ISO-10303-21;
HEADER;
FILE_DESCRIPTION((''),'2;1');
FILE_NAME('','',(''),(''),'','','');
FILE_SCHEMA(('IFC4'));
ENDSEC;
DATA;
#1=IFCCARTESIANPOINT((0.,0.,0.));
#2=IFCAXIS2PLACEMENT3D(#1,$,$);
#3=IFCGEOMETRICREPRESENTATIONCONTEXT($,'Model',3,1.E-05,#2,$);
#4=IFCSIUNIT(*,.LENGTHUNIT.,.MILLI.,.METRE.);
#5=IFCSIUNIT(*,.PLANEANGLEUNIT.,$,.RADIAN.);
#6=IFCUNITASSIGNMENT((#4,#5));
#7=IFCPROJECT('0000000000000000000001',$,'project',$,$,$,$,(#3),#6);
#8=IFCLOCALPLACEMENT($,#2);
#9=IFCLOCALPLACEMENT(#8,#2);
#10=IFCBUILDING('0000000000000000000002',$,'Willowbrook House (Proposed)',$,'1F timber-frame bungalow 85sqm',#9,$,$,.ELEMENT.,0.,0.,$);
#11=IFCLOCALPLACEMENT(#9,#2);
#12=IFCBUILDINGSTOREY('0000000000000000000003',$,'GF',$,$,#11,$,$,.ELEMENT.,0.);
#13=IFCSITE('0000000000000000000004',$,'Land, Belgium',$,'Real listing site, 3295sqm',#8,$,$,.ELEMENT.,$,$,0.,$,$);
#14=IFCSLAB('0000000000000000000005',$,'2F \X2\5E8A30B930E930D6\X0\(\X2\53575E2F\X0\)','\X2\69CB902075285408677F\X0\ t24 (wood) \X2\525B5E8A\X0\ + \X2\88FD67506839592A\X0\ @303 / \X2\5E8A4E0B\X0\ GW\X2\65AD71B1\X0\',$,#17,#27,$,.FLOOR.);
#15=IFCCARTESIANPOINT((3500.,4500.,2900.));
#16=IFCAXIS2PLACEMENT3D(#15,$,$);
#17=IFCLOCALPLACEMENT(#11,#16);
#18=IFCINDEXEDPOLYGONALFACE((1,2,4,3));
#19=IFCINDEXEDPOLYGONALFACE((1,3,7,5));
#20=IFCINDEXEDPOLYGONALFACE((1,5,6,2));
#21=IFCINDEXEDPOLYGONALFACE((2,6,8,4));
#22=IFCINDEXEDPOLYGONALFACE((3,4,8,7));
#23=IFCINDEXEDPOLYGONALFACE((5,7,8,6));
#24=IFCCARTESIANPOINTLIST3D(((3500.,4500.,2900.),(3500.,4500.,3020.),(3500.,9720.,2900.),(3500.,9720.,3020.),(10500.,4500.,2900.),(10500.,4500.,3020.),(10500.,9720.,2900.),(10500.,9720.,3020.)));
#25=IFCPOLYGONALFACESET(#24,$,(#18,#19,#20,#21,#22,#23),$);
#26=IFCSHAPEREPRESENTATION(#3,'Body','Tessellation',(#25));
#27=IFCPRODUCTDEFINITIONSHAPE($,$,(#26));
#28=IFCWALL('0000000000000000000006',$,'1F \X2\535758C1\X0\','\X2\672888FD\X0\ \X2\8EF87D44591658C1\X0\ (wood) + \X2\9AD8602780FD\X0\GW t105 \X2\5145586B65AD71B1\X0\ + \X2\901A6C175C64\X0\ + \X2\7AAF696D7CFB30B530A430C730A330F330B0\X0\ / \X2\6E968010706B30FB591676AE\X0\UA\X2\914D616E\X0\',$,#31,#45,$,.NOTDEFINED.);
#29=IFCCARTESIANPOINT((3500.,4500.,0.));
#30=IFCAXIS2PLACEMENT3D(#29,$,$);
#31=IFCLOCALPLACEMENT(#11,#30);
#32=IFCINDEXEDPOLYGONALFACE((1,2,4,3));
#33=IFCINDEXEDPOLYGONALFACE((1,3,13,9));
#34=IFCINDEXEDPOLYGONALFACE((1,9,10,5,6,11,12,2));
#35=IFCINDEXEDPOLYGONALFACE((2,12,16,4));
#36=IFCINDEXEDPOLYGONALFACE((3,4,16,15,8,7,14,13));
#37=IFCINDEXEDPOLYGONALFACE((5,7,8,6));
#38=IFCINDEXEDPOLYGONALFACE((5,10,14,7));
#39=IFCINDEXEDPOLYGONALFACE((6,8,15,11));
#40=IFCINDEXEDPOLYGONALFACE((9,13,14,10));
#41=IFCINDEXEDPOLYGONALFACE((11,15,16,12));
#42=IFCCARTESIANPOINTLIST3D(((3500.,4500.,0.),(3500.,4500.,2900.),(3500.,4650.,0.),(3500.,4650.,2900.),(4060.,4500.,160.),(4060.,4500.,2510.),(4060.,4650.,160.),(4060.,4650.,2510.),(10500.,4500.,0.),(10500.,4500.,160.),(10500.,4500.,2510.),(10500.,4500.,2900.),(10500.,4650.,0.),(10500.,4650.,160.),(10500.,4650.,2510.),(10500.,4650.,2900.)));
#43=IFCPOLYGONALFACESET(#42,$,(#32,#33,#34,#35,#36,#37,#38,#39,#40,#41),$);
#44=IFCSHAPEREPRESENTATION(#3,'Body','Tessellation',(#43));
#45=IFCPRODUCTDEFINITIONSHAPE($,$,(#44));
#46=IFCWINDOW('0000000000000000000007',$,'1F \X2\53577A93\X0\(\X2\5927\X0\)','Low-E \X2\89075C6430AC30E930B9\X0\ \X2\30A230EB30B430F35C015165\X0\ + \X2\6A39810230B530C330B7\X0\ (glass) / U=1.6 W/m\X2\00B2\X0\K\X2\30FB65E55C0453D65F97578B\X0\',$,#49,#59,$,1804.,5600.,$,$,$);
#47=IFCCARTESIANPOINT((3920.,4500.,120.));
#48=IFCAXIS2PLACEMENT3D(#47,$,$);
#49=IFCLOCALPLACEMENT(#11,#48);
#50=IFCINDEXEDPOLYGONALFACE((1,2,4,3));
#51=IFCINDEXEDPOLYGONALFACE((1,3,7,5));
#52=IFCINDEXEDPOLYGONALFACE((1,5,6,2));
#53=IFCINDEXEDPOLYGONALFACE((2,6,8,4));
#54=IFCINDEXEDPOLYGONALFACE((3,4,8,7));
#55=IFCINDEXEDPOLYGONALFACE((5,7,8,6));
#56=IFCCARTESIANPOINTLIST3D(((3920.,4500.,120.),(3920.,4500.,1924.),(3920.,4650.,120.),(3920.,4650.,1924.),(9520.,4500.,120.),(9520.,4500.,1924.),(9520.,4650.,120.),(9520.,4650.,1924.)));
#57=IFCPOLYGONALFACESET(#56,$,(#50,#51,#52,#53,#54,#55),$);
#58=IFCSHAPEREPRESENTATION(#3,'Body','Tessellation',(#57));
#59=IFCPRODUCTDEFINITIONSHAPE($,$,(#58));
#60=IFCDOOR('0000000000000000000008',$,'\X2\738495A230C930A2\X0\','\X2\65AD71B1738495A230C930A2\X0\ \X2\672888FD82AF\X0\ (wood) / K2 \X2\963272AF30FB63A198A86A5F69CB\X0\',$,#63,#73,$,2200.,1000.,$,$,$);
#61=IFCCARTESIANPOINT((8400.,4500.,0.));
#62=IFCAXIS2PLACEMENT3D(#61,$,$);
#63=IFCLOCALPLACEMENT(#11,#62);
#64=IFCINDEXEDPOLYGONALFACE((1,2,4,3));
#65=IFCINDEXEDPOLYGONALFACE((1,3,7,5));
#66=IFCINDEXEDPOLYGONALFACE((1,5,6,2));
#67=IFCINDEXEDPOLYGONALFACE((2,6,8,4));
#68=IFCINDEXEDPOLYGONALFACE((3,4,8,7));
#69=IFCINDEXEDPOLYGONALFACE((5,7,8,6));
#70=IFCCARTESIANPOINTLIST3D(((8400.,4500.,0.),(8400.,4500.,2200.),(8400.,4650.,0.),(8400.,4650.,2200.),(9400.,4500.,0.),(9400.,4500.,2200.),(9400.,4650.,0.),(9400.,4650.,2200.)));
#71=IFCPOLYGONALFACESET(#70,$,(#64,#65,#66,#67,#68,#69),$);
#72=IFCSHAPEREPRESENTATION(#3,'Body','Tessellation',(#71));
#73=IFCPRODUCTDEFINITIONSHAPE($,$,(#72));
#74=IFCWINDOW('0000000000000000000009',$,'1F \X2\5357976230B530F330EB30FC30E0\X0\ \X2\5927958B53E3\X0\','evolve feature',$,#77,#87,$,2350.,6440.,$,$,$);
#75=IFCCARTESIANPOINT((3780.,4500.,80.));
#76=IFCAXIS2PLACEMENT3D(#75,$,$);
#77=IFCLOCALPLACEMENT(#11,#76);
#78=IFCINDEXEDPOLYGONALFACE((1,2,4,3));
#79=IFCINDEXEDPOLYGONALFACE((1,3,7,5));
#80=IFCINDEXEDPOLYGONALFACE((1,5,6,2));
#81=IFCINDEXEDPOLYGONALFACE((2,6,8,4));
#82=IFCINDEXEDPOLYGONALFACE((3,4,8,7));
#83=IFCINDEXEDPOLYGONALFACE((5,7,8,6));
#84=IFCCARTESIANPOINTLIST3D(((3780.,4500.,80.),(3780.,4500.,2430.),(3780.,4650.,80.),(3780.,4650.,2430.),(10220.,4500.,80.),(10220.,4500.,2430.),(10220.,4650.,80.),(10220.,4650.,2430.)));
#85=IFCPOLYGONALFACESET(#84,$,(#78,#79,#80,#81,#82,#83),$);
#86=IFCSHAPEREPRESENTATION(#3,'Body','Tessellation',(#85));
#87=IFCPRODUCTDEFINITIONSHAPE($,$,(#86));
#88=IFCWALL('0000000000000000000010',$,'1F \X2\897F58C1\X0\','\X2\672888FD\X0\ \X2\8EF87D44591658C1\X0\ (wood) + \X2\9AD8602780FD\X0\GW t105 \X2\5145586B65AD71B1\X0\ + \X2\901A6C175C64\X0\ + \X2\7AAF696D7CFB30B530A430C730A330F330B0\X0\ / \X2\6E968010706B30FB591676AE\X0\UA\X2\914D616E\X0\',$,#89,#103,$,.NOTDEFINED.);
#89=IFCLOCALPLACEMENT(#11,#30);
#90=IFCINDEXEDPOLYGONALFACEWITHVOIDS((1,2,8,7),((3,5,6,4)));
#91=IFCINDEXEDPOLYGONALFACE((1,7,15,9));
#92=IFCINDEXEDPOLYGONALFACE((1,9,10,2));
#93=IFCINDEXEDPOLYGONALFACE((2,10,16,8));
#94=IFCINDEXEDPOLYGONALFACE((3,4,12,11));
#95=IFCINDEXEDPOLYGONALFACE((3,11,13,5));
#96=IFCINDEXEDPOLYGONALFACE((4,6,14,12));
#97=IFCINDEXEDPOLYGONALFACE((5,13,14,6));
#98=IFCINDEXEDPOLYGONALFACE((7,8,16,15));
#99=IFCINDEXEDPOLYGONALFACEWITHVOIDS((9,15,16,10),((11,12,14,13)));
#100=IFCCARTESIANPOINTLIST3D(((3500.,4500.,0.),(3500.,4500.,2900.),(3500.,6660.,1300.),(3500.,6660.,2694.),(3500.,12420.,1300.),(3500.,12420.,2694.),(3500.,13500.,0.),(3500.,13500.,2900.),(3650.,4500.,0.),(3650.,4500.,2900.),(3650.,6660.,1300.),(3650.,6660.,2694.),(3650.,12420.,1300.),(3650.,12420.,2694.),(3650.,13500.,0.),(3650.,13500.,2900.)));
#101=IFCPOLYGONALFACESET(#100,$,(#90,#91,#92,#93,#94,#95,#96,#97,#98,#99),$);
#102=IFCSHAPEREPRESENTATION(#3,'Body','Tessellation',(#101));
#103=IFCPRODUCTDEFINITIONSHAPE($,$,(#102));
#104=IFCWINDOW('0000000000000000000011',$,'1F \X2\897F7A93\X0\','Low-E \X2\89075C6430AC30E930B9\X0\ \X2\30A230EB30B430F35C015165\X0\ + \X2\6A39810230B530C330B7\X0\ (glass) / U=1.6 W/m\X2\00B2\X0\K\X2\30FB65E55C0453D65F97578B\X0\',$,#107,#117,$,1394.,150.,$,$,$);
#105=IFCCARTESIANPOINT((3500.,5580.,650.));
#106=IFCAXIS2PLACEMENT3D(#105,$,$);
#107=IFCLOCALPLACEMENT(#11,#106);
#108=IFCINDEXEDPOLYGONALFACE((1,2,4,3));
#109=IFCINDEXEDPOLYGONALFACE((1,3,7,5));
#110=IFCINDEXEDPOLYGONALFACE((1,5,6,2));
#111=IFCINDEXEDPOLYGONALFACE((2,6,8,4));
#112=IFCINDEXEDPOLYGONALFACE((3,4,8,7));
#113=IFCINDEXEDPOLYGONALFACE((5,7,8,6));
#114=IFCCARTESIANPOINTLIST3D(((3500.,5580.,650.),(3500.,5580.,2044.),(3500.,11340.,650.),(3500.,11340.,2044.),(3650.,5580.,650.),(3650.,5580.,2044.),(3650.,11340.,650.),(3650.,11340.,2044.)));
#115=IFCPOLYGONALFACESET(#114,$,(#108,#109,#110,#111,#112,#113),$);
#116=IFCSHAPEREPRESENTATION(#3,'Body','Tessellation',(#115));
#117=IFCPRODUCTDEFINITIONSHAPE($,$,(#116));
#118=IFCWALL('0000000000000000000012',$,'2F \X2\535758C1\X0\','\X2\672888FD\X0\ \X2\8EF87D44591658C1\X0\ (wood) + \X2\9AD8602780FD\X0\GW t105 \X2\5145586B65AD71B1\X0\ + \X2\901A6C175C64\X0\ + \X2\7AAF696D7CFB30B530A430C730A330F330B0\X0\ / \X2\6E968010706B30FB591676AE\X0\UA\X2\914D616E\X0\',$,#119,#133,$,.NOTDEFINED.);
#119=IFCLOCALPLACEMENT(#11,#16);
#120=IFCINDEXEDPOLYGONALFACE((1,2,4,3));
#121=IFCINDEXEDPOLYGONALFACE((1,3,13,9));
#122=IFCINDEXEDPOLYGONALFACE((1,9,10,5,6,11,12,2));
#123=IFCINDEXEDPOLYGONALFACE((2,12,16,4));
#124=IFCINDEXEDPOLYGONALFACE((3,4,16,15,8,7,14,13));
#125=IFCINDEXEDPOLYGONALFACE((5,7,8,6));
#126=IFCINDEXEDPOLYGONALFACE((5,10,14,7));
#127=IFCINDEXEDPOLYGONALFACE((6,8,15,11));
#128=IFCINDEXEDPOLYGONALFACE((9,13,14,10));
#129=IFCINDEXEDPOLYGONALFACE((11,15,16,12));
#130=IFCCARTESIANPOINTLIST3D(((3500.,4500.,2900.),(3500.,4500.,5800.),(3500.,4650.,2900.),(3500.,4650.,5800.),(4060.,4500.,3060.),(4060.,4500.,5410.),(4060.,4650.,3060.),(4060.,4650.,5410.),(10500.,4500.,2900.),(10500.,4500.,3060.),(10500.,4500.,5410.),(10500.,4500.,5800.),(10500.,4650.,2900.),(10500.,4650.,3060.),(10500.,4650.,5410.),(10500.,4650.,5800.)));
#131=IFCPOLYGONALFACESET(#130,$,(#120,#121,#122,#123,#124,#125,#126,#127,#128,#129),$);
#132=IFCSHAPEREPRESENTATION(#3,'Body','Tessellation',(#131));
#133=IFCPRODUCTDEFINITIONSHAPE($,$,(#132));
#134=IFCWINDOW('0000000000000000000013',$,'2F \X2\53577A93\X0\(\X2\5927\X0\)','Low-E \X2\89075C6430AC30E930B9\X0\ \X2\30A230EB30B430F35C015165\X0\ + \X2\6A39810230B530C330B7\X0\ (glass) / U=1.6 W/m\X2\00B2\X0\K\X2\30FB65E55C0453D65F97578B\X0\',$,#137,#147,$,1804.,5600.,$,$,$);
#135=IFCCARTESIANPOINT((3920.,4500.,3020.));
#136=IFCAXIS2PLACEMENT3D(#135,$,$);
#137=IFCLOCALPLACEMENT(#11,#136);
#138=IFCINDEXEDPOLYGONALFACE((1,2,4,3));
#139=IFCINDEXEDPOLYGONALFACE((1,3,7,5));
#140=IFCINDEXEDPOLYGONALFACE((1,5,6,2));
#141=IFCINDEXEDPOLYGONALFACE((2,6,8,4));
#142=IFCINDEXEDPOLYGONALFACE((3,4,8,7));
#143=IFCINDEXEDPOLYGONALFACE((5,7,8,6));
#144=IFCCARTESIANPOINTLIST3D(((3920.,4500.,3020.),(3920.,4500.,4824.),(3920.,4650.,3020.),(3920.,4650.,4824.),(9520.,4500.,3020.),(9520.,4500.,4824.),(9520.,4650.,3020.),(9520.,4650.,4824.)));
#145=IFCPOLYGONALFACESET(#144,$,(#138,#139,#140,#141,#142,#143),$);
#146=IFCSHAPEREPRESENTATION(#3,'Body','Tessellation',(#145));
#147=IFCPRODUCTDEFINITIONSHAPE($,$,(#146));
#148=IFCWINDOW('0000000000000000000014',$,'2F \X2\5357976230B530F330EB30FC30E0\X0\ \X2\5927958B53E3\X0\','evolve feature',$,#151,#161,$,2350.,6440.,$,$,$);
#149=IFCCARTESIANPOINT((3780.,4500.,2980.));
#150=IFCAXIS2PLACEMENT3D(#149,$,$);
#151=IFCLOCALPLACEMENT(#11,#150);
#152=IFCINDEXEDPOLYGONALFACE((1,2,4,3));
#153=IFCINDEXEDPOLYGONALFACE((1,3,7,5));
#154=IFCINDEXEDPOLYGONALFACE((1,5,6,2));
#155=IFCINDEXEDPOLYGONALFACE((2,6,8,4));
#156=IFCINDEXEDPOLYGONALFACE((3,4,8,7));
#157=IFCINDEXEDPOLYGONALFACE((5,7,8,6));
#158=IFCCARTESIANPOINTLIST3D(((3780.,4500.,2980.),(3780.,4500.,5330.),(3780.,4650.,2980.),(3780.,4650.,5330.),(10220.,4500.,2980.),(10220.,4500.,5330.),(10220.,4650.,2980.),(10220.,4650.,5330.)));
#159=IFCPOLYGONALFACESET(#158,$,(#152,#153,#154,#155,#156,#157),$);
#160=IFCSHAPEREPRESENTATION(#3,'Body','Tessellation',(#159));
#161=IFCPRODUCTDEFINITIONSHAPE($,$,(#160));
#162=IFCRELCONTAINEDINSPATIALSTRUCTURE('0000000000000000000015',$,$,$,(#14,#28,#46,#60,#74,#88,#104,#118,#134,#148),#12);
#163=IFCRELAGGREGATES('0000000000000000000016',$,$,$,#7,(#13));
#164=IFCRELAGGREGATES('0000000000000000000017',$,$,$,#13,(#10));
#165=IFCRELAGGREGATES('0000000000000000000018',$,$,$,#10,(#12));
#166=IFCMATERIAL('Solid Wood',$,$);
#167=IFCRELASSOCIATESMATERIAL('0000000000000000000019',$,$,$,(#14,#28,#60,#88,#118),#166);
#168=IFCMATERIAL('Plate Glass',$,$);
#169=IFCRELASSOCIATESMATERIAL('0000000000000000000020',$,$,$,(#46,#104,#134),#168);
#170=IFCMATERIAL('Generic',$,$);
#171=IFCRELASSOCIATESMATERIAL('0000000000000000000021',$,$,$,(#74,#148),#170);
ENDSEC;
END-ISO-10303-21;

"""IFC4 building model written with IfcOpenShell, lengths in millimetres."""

from ifc_helpers import new_model, si_unit, frame, frame_2d, origin, place, context, project, spatial, rectangle, extrude, material, element, fill, save


model = new_model("IFC4")

# Units and contexts
model_context = context("Model", 3, precision=1e-05, world=origin())
ifc_project = project(units=[si_unit("LENGTHUNIT", "METRE", prefix="MILLI"), si_unit("PLANEANGLEUNIT", "RADIAN")], contexts=[model_context])

# Site, building, storey
site_placement = place(None, origin())
site = spatial("IfcSite", under=ifc_project, at=site_placement, Name="Land, Belgium", ObjectType="Real listing site, 3295sqm", CompositionType="ELEMENT", RefElevation=0.0)
building_placement = place(site_placement, origin())
building = spatial("IfcBuilding", under=site, at=building_placement, Name="Willowbrook House (Proposed)", ObjectType="1F timber-frame bungalow 85sqm", CompositionType="ELEMENT", ElevationOfRefHeight=0.0, ElevationOfTerrain=0.0)
storey_placement = place(building_placement, origin())
storey = spatial("IfcBuildingStorey", under=building, at=storey_placement, Name="GF", CompositionType="ELEMENT", Elevation=0.0)

# Slab
ifc_material_1 = material(Name="Solid Wood")
slab_1_placement = place(storey_placement, frame((3500.0, 4500.0, 2900.0)))
element("IfcSlab", 1, at=slab_1_placement, inside=storey, material=ifc_material_1, Name="2F 床スラブ(南帯)", Description="構造用合板 t24 (wood) 剛床 + 製材根太 @303 / 床下 GW断熱", PredefinedType="FLOOR", context=model_context, shape_type="SweptSolid", body=[
    extrude(rectangle(XDim=7000.0, YDim=5220.0, at=frame_2d((3500.0, 2610.0))), frame((3500.0, 4500.0, 2900.0)), (0.0, 0.0, 1.0), 120.0),
])
ifc_material_2 = material(Name="Generic")

# Wall, openings, windows, door
wall_1_placement = place(storey_placement, frame((3500.0, 4500.0, 0.0)))
wall_1 = element("IfcWall", 2, at=wall_1_placement, inside=storey, material=ifc_material_1, Name="1F 南壁", Description="木製 軸組外壁 (wood) + 高性能GW t105 充填断熱 + 通気層 + 窯業系サイディング / 準耐火・外皮UA配慮", PredefinedType="NOTDEFINED", context=model_context, shape_type="SweptSolid", body=[
    extrude(rectangle(XDim=7000.0, YDim=150.0, at=frame_2d((3500.0, 75.0))), frame((3500.0, 4500.0, 0.0)), (0.0, 0.0, 1.0), 2900.0),
])
opening_1_placement = place(storey_placement, frame((3920.0, 4500.0, 120.0)))
opening_1 = element("IfcOpeningElement", 3, at=opening_1_placement, cuts=wall_1, PredefinedType="NOTDEFINED", context=model_context, shape_type="SweptSolid", body=[
    extrude(rectangle(XDim=5600.0, YDim=150.0, at=frame_2d((2800.0, 75.0))), frame((3920.0, 4500.0, 120.0)), (0.0, 0.0, 1.0), 1804.0),
])
opening_2_placement = place(storey_placement, frame((8400.0, 4500.0, 0.0)))
opening_2 = element("IfcOpeningElement", 4, at=opening_2_placement, cuts=wall_1, PredefinedType="NOTDEFINED", context=model_context, shape_type="SweptSolid", body=[
    extrude(rectangle(XDim=1000.0, YDim=150.0, at=frame_2d((500.0, 75.0))), frame((8400.0, 4500.0, 0.0)), (0.0, 0.0, 1.0), 2200.0),
])
opening_3_placement = place(storey_placement, frame((3780.0, 4500.0, 80.0)))
opening_3 = element("IfcOpeningElement", 5, at=opening_3_placement, cuts=wall_1, PredefinedType="NOTDEFINED", context=model_context, shape_type="SweptSolid", body=[
    extrude(rectangle(XDim=6440.0, YDim=150.0, at=frame_2d((3220.0, 75.0))), frame((3780.0, 4500.0, 80.0)), (0.0, 0.0, 1.0), 2350.0),
])
ifc_material_3 = material(Name="Plate Glass")
window_1_placement = place(storey_placement, frame((3920.0, 4500.0, 120.0)))
window_1 = element("IfcWindow", 6, at=window_1_placement, inside=storey, material=ifc_material_3, Name="1F 南窓(大)", Description="Low-E 複層ガラス アルゴン封入 + 樹脂サッシ (glass) / U=1.6 W/m²K・日射取得型", OverallHeight=1804.0, OverallWidth=5600.0, context=model_context, shape_type="SweptSolid", body=[
    extrude(rectangle(XDim=5600.0, YDim=150.0, at=frame_2d((2800.0, 75.0))), frame((3920.0, 4500.0, 120.0)), (0.0, 0.0, 1.0), 1804.0),
])
fill(opening_1, window_1)
door_placement = place(storey_placement, frame((8400.0, 4500.0, 0.0)))
door = element("IfcDoor", 7, at=door_placement, inside=storey, material=ifc_material_1, Name="玄関ドア", Description="断熱玄関ドア 木製芯 (wood) / K2 防犯・採風機構", OverallHeight=2200.0, OverallWidth=1000.0, context=model_context, shape_type="SweptSolid", body=[
    extrude(rectangle(XDim=1000.0, YDim=150.0, at=frame_2d((500.0, 75.0))), frame((8400.0, 4500.0, 0.0)), (0.0, 0.0, 1.0), 2200.0),
])
fill(opening_2, door)
window_2_placement = place(storey_placement, frame((3780.0, 4500.0, 80.0)))
window_2 = element("IfcWindow", 8, at=window_2_placement, inside=storey, material=ifc_material_2, Name="1F 南面サンルーム 大開口", Description="evolve feature", OverallHeight=2350.0, OverallWidth=6440.0, context=model_context, shape_type="SweptSolid", body=[
    extrude(rectangle(XDim=6440.0, YDim=150.0, at=frame_2d((3220.0, 75.0))), frame((3780.0, 4500.0, 80.0)), (0.0, 0.0, 1.0), 2350.0),
])
fill(opening_3, window_2)

# Wall, opening, window
wall_2_placement = place(storey_placement, frame((3500.0, 4500.0, 0.0)))
wall_2 = element("IfcWall", 9, at=wall_2_placement, inside=storey, material=ifc_material_1, Name="1F 西壁", Description="木製 軸組外壁 (wood) + 高性能GW t105 充填断熱 + 通気層 + 窯業系サイディング / 準耐火・外皮UA配慮", PredefinedType="NOTDEFINED", context=model_context, shape_type="SweptSolid", body=[
    extrude(rectangle(XDim=150.0, YDim=9000.0, at=frame_2d((75.0, 4500.0))), frame((3500.0, 4500.0, 0.0)), (0.0, 0.0, 1.0), 2900.0),
])
opening_4_placement = place(storey_placement, frame((3500.0, 5580.0, 650.0)))
opening_4 = element("IfcOpeningElement", 10, at=opening_4_placement, cuts=wall_2, PredefinedType="NOTDEFINED", context=model_context, shape_type="SweptSolid", body=[
    extrude(rectangle(XDim=150.0, YDim=5760.0, at=frame_2d((75.0, 2880.0))), frame((3500.0, 5580.0, 650.0)), (0.0, 0.0, 1.0), 1394.0),
])
window_3_placement = place(storey_placement, frame((3500.0, 5580.0, 650.0)))
window_3 = element("IfcWindow", 11, at=window_3_placement, inside=storey, material=ifc_material_3, Name="1F 西窓", Description="Low-E 複層ガラス アルゴン封入 + 樹脂サッシ (glass) / U=1.6 W/m²K・日射取得型", OverallHeight=1394.0, OverallWidth=150.0, context=model_context, shape_type="SweptSolid", body=[
    extrude(rectangle(XDim=150.0, YDim=5760.0, at=frame_2d((75.0, 2880.0))), frame((3500.0, 5580.0, 650.0)), (0.0, 0.0, 1.0), 1394.0),
])
fill(opening_4, window_3)

# Wall, openings, windows
wall_3_placement = place(storey_placement, frame((3500.0, 4500.0, 2900.0)))
wall_3 = element("IfcWall", 12, at=wall_3_placement, inside=storey, material=ifc_material_1, Name="2F 南壁", Description="木製 軸組外壁 (wood) + 高性能GW t105 充填断熱 + 通気層 + 窯業系サイディング / 準耐火・外皮UA配慮", PredefinedType="NOTDEFINED", context=model_context, shape_type="SweptSolid", body=[
    extrude(rectangle(XDim=7000.0, YDim=150.0, at=frame_2d((3500.0, 75.0))), frame((3500.0, 4500.0, 2900.0)), (0.0, 0.0, 1.0), 2900.0),
])
opening_5_placement = place(storey_placement, frame((3920.0, 4500.0, 3020.0)))
opening_5 = element("IfcOpeningElement", 13, at=opening_5_placement, cuts=wall_3, PredefinedType="NOTDEFINED", context=model_context, shape_type="SweptSolid", body=[
    extrude(rectangle(XDim=5600.0, YDim=150.0, at=frame_2d((2800.0, 75.0))), frame((3920.0, 4500.0, 3020.0)), (0.0, 0.0, 1.0), 1804.0),
])
opening_6_placement = place(storey_placement, frame((3780.0, 4500.0, 2980.0)))
opening_6 = element("IfcOpeningElement", 14, at=opening_6_placement, cuts=wall_3, PredefinedType="NOTDEFINED", context=model_context, shape_type="SweptSolid", body=[
    extrude(rectangle(XDim=6440.0, YDim=150.0, at=frame_2d((3220.0, 75.0))), frame((3780.0, 4500.0, 2980.0)), (0.0, 0.0, 1.0), 2350.0),
])
window_4_placement = place(storey_placement, frame((3920.0, 4500.0, 3020.0)))
window_4 = element("IfcWindow", 15, at=window_4_placement, inside=storey, material=ifc_material_3, Name="2F 南窓(大)", Description="Low-E 複層ガラス アルゴン封入 + 樹脂サッシ (glass) / U=1.6 W/m²K・日射取得型", OverallHeight=1804.0, OverallWidth=5600.0, context=model_context, shape_type="SweptSolid", body=[
    extrude(rectangle(XDim=5600.0, YDim=150.0, at=frame_2d((2800.0, 75.0))), frame((3920.0, 4500.0, 3020.0)), (0.0, 0.0, 1.0), 1804.0),
])
fill(opening_5, window_4)
window_5_placement = place(storey_placement, frame((3780.0, 4500.0, 2980.0)))
window_5 = element("IfcWindow", 16, at=window_5_placement, inside=storey, material=ifc_material_2, Name="2F 南面サンルーム 大開口", Description="evolve feature", OverallHeight=2350.0, OverallWidth=6440.0, context=model_context, shape_type="SweptSolid", body=[
    extrude(rectangle(XDim=6440.0, YDim=150.0, at=frame_2d((3220.0, 75.0))), frame((3780.0, 4500.0, 2980.0)), (0.0, 0.0, 1.0), 2350.0),
])
fill(opening_6, window_5)

save(model, "model.ifc")
